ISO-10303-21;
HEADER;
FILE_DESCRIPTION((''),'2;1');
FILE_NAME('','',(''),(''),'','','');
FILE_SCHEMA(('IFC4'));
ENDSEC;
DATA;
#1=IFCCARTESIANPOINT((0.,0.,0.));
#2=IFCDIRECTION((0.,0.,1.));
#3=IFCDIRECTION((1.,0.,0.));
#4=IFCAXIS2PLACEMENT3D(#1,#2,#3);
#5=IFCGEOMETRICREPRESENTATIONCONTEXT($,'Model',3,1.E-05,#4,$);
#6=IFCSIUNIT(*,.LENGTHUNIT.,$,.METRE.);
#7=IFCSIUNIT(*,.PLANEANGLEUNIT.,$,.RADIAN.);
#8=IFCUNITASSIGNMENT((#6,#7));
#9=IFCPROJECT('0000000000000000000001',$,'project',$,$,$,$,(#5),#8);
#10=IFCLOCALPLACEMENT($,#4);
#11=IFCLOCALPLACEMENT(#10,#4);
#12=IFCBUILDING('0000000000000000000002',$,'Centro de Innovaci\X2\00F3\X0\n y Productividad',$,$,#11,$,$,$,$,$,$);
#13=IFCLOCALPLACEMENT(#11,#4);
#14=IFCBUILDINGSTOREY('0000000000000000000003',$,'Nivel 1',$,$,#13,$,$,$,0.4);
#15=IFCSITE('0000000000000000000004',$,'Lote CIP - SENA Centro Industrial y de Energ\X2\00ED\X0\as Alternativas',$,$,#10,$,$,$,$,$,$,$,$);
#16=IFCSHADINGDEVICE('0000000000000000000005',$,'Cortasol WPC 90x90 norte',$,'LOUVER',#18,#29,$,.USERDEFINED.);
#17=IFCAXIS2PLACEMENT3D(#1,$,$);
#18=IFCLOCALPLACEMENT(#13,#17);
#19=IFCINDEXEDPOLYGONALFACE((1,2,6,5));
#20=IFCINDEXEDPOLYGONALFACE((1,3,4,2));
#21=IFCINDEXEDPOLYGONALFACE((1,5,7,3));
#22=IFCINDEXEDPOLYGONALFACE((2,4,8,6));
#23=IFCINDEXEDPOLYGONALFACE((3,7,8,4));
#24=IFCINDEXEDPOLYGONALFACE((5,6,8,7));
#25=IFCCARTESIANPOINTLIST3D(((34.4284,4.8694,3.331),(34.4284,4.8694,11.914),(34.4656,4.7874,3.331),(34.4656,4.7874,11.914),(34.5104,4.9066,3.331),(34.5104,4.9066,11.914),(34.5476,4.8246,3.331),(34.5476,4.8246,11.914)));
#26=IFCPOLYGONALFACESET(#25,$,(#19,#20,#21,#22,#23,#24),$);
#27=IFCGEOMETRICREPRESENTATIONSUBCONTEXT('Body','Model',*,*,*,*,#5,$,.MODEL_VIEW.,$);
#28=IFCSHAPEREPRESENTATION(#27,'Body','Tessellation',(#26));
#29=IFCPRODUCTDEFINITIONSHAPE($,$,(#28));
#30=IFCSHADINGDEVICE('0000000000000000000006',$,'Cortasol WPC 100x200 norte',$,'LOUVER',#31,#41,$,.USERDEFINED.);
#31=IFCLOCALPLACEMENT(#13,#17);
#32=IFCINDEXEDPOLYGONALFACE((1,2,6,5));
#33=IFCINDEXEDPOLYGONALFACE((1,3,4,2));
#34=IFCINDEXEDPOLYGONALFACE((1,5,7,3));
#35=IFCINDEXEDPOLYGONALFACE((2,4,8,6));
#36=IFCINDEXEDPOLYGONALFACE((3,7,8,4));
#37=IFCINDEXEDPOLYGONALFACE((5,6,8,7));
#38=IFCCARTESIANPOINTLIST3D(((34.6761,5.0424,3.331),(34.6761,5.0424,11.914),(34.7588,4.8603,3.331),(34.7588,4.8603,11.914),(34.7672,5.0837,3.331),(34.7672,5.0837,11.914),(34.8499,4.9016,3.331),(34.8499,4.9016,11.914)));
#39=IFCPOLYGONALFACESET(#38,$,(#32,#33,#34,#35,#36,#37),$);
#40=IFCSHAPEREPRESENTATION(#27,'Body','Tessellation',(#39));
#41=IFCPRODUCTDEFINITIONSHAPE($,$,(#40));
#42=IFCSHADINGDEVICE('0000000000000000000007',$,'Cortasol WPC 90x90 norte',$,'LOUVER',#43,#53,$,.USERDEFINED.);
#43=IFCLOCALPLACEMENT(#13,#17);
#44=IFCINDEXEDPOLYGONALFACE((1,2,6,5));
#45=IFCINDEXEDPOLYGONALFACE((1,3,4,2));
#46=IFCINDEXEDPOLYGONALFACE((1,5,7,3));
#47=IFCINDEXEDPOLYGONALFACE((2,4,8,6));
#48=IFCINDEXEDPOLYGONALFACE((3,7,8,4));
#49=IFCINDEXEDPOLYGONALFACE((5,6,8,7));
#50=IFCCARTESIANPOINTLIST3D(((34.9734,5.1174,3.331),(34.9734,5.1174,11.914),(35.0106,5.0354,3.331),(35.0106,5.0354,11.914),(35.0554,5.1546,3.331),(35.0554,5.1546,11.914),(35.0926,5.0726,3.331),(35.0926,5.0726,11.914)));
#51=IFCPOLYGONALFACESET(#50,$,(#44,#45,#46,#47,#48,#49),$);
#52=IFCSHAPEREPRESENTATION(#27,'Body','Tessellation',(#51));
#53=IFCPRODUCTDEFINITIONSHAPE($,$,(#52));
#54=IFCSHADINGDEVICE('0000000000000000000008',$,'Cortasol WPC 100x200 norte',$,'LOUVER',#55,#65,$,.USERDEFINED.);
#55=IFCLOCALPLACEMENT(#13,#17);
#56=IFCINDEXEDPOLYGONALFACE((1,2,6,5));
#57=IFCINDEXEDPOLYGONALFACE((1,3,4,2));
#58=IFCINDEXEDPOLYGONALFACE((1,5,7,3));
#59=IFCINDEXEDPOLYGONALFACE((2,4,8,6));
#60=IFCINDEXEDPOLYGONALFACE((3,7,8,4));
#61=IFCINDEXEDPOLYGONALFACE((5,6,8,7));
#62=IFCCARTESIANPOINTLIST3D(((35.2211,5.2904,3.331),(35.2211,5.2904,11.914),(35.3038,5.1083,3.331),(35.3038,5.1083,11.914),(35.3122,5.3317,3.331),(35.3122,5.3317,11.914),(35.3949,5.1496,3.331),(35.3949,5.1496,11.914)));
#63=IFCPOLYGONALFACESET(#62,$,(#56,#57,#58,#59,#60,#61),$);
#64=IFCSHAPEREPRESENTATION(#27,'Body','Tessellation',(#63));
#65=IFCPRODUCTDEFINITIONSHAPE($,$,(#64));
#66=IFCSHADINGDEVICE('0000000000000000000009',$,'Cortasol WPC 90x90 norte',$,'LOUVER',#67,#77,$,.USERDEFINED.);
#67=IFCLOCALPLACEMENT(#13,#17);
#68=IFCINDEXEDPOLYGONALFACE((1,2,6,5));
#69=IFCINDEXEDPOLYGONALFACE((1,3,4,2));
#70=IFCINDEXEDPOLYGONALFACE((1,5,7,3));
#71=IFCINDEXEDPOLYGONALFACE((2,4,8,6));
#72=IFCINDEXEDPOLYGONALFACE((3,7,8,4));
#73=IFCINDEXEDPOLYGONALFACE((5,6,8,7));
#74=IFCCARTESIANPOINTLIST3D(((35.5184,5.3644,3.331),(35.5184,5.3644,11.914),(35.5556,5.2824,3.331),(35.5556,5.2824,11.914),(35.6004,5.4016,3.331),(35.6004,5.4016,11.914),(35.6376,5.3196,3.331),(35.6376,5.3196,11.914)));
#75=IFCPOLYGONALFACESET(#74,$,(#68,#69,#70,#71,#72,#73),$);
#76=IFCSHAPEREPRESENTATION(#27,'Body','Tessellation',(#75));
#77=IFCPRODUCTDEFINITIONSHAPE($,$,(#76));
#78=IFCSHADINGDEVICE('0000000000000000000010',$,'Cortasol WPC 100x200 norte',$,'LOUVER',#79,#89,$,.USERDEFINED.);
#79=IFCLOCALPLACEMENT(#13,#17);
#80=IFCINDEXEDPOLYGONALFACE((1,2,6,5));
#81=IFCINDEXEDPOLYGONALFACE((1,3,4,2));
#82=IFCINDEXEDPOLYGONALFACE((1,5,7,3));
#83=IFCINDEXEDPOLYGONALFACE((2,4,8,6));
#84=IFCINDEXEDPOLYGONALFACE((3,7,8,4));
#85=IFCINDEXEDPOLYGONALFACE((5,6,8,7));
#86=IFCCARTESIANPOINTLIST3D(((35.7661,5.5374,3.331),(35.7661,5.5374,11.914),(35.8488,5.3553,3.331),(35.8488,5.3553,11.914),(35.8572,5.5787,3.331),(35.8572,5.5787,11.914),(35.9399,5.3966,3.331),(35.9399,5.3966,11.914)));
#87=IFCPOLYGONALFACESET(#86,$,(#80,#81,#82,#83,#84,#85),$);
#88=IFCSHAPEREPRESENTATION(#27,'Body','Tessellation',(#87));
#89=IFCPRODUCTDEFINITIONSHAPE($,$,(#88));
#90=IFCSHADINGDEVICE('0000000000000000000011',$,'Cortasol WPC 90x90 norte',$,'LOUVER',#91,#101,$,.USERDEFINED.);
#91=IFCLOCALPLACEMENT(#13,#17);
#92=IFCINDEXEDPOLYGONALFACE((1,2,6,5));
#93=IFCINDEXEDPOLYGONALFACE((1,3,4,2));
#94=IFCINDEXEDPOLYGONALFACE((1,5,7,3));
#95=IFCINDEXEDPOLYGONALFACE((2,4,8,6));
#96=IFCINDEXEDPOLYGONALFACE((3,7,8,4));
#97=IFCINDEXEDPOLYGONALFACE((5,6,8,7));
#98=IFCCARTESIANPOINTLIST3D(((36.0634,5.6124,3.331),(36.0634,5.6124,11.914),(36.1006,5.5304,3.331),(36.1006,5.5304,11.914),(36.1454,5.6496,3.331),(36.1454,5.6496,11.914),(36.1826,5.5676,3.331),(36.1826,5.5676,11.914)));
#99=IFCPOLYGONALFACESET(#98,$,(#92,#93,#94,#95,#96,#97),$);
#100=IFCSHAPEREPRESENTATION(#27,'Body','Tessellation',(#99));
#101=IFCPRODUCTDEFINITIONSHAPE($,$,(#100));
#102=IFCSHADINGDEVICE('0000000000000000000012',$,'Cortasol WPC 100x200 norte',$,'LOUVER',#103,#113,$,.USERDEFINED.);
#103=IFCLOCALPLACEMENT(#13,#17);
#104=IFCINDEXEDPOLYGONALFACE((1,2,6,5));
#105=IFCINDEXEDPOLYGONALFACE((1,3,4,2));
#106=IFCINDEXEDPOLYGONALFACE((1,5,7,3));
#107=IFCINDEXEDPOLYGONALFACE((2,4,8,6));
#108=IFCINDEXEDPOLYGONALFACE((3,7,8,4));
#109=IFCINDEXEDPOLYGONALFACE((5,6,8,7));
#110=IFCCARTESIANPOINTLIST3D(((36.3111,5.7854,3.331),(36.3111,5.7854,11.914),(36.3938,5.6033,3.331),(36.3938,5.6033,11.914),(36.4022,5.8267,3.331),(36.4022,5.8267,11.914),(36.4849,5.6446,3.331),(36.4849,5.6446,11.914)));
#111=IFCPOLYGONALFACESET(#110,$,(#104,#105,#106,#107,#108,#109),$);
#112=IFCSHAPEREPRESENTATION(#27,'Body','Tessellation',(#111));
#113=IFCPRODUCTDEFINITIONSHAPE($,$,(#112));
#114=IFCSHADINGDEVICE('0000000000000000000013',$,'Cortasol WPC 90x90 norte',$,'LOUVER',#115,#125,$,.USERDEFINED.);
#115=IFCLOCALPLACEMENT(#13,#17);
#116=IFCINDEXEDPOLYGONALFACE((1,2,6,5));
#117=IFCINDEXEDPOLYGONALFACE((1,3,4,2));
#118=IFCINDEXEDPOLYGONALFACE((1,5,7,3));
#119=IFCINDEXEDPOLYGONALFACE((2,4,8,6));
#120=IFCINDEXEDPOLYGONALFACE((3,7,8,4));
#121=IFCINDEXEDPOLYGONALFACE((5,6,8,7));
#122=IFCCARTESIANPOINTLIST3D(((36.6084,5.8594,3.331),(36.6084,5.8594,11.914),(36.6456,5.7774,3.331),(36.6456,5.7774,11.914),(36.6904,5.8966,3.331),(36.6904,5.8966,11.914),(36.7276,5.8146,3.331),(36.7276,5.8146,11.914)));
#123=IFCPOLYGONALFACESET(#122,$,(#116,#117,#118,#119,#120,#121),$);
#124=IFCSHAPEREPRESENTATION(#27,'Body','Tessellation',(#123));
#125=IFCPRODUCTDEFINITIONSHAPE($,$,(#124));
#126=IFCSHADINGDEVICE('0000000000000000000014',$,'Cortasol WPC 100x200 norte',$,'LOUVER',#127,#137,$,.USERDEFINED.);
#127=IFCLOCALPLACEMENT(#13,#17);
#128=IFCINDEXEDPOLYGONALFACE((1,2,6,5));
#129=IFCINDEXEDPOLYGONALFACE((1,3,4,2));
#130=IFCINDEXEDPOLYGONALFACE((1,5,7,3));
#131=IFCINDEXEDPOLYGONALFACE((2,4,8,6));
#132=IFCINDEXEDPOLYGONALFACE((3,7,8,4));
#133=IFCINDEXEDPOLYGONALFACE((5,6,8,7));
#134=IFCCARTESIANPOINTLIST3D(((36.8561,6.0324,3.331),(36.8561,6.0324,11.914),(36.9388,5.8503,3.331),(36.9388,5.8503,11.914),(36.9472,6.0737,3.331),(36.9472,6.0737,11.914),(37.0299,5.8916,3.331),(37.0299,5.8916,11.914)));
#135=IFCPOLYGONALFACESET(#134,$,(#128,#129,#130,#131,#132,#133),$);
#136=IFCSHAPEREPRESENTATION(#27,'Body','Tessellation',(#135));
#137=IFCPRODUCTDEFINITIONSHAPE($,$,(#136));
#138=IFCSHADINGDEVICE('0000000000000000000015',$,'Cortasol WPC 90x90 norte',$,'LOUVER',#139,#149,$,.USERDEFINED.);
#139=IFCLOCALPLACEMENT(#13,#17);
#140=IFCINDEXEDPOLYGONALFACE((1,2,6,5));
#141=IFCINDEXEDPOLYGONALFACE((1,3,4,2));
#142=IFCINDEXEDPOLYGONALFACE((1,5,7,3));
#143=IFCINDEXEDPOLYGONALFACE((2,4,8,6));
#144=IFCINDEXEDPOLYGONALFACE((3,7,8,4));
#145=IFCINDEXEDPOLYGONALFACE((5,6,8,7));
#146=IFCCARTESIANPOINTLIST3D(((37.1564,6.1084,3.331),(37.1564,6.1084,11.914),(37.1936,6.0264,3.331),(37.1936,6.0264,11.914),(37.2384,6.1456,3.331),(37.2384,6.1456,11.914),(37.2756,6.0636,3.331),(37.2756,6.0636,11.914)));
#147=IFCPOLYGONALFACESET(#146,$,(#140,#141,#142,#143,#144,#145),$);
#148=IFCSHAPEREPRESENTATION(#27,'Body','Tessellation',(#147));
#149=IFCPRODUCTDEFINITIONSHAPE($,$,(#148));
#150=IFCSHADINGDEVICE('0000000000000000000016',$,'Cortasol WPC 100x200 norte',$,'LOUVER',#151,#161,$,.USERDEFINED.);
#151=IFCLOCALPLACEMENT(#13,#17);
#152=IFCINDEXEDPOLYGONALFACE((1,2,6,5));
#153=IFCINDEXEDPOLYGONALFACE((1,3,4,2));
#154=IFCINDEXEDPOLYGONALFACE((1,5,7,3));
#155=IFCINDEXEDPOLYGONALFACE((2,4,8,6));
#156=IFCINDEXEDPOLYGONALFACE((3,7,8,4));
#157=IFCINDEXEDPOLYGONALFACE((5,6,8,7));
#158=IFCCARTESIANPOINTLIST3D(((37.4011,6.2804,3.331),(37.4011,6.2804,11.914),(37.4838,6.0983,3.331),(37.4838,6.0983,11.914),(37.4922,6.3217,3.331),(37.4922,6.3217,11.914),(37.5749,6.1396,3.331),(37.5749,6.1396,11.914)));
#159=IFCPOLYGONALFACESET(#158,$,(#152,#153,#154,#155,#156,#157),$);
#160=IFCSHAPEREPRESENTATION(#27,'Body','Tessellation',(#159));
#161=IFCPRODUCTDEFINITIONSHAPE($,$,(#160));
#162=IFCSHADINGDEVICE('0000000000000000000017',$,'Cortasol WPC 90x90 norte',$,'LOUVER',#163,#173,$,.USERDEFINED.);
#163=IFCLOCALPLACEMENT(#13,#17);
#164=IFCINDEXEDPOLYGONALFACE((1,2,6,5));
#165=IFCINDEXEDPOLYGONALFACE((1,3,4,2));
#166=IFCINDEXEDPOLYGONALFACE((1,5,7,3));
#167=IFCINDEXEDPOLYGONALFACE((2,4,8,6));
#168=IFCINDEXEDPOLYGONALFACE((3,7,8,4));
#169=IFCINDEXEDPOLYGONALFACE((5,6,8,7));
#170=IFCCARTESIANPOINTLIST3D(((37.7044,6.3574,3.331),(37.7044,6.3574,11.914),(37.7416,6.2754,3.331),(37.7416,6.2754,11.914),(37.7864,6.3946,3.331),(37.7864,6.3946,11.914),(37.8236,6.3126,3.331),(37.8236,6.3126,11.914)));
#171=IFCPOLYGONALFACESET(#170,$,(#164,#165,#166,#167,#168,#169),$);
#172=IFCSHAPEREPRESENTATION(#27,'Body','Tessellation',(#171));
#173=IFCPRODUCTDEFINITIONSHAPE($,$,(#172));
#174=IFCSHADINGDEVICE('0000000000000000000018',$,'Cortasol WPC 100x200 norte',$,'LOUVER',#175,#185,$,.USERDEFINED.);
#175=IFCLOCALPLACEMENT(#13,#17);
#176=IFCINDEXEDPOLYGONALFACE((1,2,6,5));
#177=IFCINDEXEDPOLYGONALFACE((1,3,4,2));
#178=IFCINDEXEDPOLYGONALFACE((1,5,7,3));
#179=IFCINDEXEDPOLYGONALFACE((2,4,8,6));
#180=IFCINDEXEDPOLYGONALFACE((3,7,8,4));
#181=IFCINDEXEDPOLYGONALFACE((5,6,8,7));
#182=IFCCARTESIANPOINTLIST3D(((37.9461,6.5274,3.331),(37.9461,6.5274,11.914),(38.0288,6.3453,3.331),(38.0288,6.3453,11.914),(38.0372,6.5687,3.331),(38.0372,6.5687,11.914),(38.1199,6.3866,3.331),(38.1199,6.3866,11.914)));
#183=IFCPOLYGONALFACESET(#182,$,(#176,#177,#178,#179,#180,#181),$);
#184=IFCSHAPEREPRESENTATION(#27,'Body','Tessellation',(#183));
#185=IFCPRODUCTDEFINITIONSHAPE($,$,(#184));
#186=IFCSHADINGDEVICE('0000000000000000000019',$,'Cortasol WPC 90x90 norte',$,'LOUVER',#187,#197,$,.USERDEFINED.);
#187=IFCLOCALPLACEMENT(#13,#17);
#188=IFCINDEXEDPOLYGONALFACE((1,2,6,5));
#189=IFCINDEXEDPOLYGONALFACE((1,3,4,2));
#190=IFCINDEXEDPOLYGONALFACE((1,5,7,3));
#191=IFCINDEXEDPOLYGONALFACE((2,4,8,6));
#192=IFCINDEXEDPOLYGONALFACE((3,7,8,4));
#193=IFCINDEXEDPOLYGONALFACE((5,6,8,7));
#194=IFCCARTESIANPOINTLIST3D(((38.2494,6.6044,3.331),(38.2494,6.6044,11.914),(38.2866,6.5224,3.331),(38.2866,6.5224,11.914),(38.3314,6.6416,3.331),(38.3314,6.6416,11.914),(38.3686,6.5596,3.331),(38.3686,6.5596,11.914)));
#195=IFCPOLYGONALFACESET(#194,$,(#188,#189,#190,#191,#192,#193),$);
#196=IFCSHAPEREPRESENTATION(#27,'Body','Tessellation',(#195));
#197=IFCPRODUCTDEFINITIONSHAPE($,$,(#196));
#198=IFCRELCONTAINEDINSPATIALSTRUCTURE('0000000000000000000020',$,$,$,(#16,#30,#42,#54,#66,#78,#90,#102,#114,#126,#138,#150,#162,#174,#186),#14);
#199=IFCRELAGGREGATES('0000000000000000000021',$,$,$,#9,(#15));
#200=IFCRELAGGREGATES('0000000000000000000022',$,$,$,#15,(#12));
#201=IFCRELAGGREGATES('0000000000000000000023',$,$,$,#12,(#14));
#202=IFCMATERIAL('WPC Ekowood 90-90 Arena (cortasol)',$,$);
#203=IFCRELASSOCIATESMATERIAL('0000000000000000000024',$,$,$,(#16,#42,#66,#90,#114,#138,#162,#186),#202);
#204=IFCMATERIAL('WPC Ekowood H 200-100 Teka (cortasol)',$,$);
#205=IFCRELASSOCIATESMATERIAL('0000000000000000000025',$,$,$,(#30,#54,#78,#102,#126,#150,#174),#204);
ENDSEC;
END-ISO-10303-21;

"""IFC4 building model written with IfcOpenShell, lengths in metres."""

from ifc_helpers import new_model, si_unit, frame, origin_with_axes, place, context, subcontext, project, spatial, polyline, outline, extrude, material, element, save


model = new_model("IFC4")

# Units and contexts
model_context = context("Model", 3, precision=1e-05, world=origin_with_axes())
body_context = subcontext(model_context, "Body", "Model", "MODEL_VIEW")
ifc_project = project(units=[si_unit("LENGTHUNIT", "METRE"), si_unit("PLANEANGLEUNIT", "RADIAN")], contexts=[model_context])

# Site, building, storey
site_placement = place(None, origin_with_axes())
site = spatial("IfcSite", under=ifc_project, at=site_placement, Name="Lote CIP - SENA Centro Industrial y de Energías Alternativas")
building_placement = place(site_placement, origin_with_axes())
building = spatial("IfcBuilding", under=site, at=building_placement, Name="Centro de Innovación y Productividad")
storey_placement = place(building_placement, origin_with_axes())
storey = spatial("IfcBuildingStorey", under=building, at=storey_placement, Name="Nivel 1", Elevation=0.4)

# Shading devices
ifc_material_1 = material(Name="WPC Ekowood 90-90 Arena (cortasol)")
shading_device_1_placement = place(storey_placement, origin_with_axes())
element("IfcShadingDevice", 1, at=shading_device_1_placement, inside=storey, material=ifc_material_1, Name="Cortasol WPC 90x90 norte", ObjectType="LOUVER", PredefinedType="USERDEFINED", context=body_context, shape_type="SweptSolid", body=[
    extrude(outline(polyline([(34.4656, 4.7874), (34.4284, 4.8694), (34.5104, 4.9066), (34.5476, 4.8246), (34.4656, 4.7874)])), frame((0.0, 0.0, 3.331)), (0.0, 0.0, 1.0), 8.583),
])
ifc_material_2 = material(Name="WPC Ekowood H 200-100 Teka (cortasol)")
shading_device_2_placement = place(storey_placement, origin_with_axes())
element("IfcShadingDevice", 2, at=shading_device_2_placement, inside=storey, material=ifc_material_2, Name="Cortasol WPC 100x200 norte", ObjectType="LOUVER", PredefinedType="USERDEFINED", context=body_context, shape_type="SweptSolid", body=[
    extrude(outline(polyline([(34.7588, 4.8603), (34.6761, 5.0424), (34.7672, 5.0837), (34.8499, 4.9016), (34.7588, 4.8603)])), frame((0.0, 0.0, 3.331)), (0.0, 0.0, 1.0), 8.583),
])
shading_device_3_placement = place(storey_placement, origin_with_axes())
element("IfcShadingDevice", 3, at=shading_device_3_placement, inside=storey, material=ifc_material_1, Name="Cortasol WPC 90x90 norte", ObjectType="LOUVER", PredefinedType="USERDEFINED", context=body_context, shape_type="SweptSolid", body=[
    extrude(outline(polyline([(35.0106, 5.0354), (34.9734, 5.1174), (35.0554, 5.1546), (35.0926, 5.0726), (35.0106, 5.0354)])), frame((0.0, 0.0, 3.331)), (0.0, 0.0, 1.0), 8.583),
])
shading_device_4_placement = place(storey_placement, origin_with_axes())
element("IfcShadingDevice", 4, at=shading_device_4_placement, inside=storey, material=ifc_material_2, Name="Cortasol WPC 100x200 norte", ObjectType="LOUVER", PredefinedType="USERDEFINED", context=body_context, shape_type="SweptSolid", body=[
    extrude(outline(polyline([(35.3038, 5.1083), (35.2211, 5.2904), (35.3122, 5.3317), (35.3949, 5.1496), (35.3038, 5.1083)])), frame((0.0, 0.0, 3.331)), (0.0, 0.0, 1.0), 8.583),
])
shading_device_5_placement = place(storey_placement, origin_with_axes())
element("IfcShadingDevice", 5, at=shading_device_5_placement, inside=storey, material=ifc_material_1, Name="Cortasol WPC 90x90 norte", ObjectType="LOUVER", PredefinedType="USERDEFINED", context=body_context, shape_type="SweptSolid", body=[
    extrude(outline(polyline([(35.5556, 5.2824), (35.5184, 5.3644), (35.6004, 5.4016), (35.6376, 5.3196), (35.5556, 5.2824)])), frame((0.0, 0.0, 3.331)), (0.0, 0.0, 1.0), 8.583),
])
shading_device_6_placement = place(storey_placement, origin_with_axes())
element("IfcShadingDevice", 6, at=shading_device_6_placement, inside=storey, material=ifc_material_2, Name="Cortasol WPC 100x200 norte", ObjectType="LOUVER", PredefinedType="USERDEFINED", context=body_context, shape_type="SweptSolid", body=[
    extrude(outline(polyline([(35.8488, 5.3553), (35.7661, 5.5374), (35.8572, 5.5787), (35.9399, 5.3966), (35.8488, 5.3553)])), frame((0.0, 0.0, 3.331)), (0.0, 0.0, 1.0), 8.583),
])
shading_device_7_placement = place(storey_placement, origin_with_axes())
element("IfcShadingDevice", 7, at=shading_device_7_placement, inside=storey, material=ifc_material_1, Name="Cortasol WPC 90x90 norte", ObjectType="LOUVER", PredefinedType="USERDEFINED", context=body_context, shape_type="SweptSolid", body=[
    extrude(outline(polyline([(36.1006, 5.5304), (36.0634, 5.6124), (36.1454, 5.6496), (36.1826, 5.5676), (36.1006, 5.5304)])), frame((0.0, 0.0, 3.331)), (0.0, 0.0, 1.0), 8.583),
])
shading_device_8_placement = place(storey_placement, origin_with_axes())
element("IfcShadingDevice", 8, at=shading_device_8_placement, inside=storey, material=ifc_material_2, Name="Cortasol WPC 100x200 norte", ObjectType="LOUVER", PredefinedType="USERDEFINED", context=body_context, shape_type="SweptSolid", body=[
    extrude(outline(polyline([(36.3938, 5.6033), (36.3111, 5.7854), (36.4022, 5.8267), (36.4849, 5.6446), (36.3938, 5.6033)])), frame((0.0, 0.0, 3.331)), (0.0, 0.0, 1.0), 8.583),
])
shading_device_9_placement = place(storey_placement, origin_with_axes())
element("IfcShadingDevice", 9, at=shading_device_9_placement, inside=storey, material=ifc_material_1, Name="Cortasol WPC 90x90 norte", ObjectType="LOUVER", PredefinedType="USERDEFINED", context=body_context, shape_type="SweptSolid", body=[
    extrude(outline(polyline([(36.6456, 5.7774), (36.6084, 5.8594), (36.6904, 5.8966), (36.7276, 5.8146), (36.6456, 5.7774)])), frame((0.0, 0.0, 3.331)), (0.0, 0.0, 1.0), 8.583),
])
shading_device_10_placement = place(storey_placement, origin_with_axes())
element("IfcShadingDevice", 10, at=shading_device_10_placement, inside=storey, material=ifc_material_2, Name="Cortasol WPC 100x200 norte", ObjectType="LOUVER", PredefinedType="USERDEFINED", context=body_context, shape_type="SweptSolid", body=[
    extrude(outline(polyline([(36.9388, 5.8503), (36.8561, 6.0324), (36.9472, 6.0737), (37.0299, 5.8916), (36.9388, 5.8503)])), frame((0.0, 0.0, 3.331)), (0.0, 0.0, 1.0), 8.583),
])
shading_device_11_placement = place(storey_placement, origin_with_axes())
element("IfcShadingDevice", 11, at=shading_device_11_placement, inside=storey, material=ifc_material_1, Name="Cortasol WPC 90x90 norte", ObjectType="LOUVER", PredefinedType="USERDEFINED", context=body_context, shape_type="SweptSolid", body=[
    extrude(outline(polyline([(37.1936, 6.0264), (37.1564, 6.1084), (37.2384, 6.1456), (37.2756, 6.0636), (37.1936, 6.0264)])), frame((0.0, 0.0, 3.331)), (0.0, 0.0, 1.0), 8.583),
])
shading_device_12_placement = place(storey_placement, origin_with_axes())
element("IfcShadingDevice", 12, at=shading_device_12_placement, inside=storey, material=ifc_material_2, Name="Cortasol WPC 100x200 norte", ObjectType="LOUVER", PredefinedType="USERDEFINED", context=body_context, shape_type="SweptSolid", body=[
    extrude(outline(polyline([(37.4838, 6.0983), (37.4011, 6.2804), (37.4922, 6.3217), (37.5749, 6.1396), (37.4838, 6.0983)])), frame((0.0, 0.0, 3.331)), (0.0, 0.0, 1.0), 8.583),
])
shading_device_13_placement = place(storey_placement, origin_with_axes())
element("IfcShadingDevice", 13, at=shading_device_13_placement, inside=storey, material=ifc_material_1, Name="Cortasol WPC 90x90 norte", ObjectType="LOUVER", PredefinedType="USERDEFINED", context=body_context, shape_type="SweptSolid", body=[
    extrude(outline(polyline([(37.7416, 6.2754), (37.7044, 6.3574), (37.7864, 6.3946), (37.8236, 6.3126), (37.7416, 6.2754)])), frame((0.0, 0.0, 3.331)), (0.0, 0.0, 1.0), 8.583),
])
shading_device_14_placement = place(storey_placement, origin_with_axes())
element("IfcShadingDevice", 14, at=shading_device_14_placement, inside=storey, material=ifc_material_2, Name="Cortasol WPC 100x200 norte", ObjectType="LOUVER", PredefinedType="USERDEFINED", context=body_context, shape_type="SweptSolid", body=[
    extrude(outline(polyline([(38.0288, 6.3453), (37.9461, 6.5274), (38.0372, 6.5687), (38.1199, 6.3866), (38.0288, 6.3453)])), frame((0.0, 0.0, 3.331)), (0.0, 0.0, 1.0), 8.583),
])
shading_device_15_placement = place(storey_placement, origin_with_axes())
element("IfcShadingDevice", 15, at=shading_device_15_placement, inside=storey, material=ifc_material_1, Name="Cortasol WPC 90x90 norte", ObjectType="LOUVER", PredefinedType="USERDEFINED", context=body_context, shape_type="SweptSolid", body=[
    extrude(outline(polyline([(38.2866, 6.5224), (38.2494, 6.6044), (38.3314, 6.6416), (38.3686, 6.5596), (38.2866, 6.5224)])), frame((0.0, 0.0, 3.331)), (0.0, 0.0, 1.0), 8.583),
])

save(model, "model.ifc")
